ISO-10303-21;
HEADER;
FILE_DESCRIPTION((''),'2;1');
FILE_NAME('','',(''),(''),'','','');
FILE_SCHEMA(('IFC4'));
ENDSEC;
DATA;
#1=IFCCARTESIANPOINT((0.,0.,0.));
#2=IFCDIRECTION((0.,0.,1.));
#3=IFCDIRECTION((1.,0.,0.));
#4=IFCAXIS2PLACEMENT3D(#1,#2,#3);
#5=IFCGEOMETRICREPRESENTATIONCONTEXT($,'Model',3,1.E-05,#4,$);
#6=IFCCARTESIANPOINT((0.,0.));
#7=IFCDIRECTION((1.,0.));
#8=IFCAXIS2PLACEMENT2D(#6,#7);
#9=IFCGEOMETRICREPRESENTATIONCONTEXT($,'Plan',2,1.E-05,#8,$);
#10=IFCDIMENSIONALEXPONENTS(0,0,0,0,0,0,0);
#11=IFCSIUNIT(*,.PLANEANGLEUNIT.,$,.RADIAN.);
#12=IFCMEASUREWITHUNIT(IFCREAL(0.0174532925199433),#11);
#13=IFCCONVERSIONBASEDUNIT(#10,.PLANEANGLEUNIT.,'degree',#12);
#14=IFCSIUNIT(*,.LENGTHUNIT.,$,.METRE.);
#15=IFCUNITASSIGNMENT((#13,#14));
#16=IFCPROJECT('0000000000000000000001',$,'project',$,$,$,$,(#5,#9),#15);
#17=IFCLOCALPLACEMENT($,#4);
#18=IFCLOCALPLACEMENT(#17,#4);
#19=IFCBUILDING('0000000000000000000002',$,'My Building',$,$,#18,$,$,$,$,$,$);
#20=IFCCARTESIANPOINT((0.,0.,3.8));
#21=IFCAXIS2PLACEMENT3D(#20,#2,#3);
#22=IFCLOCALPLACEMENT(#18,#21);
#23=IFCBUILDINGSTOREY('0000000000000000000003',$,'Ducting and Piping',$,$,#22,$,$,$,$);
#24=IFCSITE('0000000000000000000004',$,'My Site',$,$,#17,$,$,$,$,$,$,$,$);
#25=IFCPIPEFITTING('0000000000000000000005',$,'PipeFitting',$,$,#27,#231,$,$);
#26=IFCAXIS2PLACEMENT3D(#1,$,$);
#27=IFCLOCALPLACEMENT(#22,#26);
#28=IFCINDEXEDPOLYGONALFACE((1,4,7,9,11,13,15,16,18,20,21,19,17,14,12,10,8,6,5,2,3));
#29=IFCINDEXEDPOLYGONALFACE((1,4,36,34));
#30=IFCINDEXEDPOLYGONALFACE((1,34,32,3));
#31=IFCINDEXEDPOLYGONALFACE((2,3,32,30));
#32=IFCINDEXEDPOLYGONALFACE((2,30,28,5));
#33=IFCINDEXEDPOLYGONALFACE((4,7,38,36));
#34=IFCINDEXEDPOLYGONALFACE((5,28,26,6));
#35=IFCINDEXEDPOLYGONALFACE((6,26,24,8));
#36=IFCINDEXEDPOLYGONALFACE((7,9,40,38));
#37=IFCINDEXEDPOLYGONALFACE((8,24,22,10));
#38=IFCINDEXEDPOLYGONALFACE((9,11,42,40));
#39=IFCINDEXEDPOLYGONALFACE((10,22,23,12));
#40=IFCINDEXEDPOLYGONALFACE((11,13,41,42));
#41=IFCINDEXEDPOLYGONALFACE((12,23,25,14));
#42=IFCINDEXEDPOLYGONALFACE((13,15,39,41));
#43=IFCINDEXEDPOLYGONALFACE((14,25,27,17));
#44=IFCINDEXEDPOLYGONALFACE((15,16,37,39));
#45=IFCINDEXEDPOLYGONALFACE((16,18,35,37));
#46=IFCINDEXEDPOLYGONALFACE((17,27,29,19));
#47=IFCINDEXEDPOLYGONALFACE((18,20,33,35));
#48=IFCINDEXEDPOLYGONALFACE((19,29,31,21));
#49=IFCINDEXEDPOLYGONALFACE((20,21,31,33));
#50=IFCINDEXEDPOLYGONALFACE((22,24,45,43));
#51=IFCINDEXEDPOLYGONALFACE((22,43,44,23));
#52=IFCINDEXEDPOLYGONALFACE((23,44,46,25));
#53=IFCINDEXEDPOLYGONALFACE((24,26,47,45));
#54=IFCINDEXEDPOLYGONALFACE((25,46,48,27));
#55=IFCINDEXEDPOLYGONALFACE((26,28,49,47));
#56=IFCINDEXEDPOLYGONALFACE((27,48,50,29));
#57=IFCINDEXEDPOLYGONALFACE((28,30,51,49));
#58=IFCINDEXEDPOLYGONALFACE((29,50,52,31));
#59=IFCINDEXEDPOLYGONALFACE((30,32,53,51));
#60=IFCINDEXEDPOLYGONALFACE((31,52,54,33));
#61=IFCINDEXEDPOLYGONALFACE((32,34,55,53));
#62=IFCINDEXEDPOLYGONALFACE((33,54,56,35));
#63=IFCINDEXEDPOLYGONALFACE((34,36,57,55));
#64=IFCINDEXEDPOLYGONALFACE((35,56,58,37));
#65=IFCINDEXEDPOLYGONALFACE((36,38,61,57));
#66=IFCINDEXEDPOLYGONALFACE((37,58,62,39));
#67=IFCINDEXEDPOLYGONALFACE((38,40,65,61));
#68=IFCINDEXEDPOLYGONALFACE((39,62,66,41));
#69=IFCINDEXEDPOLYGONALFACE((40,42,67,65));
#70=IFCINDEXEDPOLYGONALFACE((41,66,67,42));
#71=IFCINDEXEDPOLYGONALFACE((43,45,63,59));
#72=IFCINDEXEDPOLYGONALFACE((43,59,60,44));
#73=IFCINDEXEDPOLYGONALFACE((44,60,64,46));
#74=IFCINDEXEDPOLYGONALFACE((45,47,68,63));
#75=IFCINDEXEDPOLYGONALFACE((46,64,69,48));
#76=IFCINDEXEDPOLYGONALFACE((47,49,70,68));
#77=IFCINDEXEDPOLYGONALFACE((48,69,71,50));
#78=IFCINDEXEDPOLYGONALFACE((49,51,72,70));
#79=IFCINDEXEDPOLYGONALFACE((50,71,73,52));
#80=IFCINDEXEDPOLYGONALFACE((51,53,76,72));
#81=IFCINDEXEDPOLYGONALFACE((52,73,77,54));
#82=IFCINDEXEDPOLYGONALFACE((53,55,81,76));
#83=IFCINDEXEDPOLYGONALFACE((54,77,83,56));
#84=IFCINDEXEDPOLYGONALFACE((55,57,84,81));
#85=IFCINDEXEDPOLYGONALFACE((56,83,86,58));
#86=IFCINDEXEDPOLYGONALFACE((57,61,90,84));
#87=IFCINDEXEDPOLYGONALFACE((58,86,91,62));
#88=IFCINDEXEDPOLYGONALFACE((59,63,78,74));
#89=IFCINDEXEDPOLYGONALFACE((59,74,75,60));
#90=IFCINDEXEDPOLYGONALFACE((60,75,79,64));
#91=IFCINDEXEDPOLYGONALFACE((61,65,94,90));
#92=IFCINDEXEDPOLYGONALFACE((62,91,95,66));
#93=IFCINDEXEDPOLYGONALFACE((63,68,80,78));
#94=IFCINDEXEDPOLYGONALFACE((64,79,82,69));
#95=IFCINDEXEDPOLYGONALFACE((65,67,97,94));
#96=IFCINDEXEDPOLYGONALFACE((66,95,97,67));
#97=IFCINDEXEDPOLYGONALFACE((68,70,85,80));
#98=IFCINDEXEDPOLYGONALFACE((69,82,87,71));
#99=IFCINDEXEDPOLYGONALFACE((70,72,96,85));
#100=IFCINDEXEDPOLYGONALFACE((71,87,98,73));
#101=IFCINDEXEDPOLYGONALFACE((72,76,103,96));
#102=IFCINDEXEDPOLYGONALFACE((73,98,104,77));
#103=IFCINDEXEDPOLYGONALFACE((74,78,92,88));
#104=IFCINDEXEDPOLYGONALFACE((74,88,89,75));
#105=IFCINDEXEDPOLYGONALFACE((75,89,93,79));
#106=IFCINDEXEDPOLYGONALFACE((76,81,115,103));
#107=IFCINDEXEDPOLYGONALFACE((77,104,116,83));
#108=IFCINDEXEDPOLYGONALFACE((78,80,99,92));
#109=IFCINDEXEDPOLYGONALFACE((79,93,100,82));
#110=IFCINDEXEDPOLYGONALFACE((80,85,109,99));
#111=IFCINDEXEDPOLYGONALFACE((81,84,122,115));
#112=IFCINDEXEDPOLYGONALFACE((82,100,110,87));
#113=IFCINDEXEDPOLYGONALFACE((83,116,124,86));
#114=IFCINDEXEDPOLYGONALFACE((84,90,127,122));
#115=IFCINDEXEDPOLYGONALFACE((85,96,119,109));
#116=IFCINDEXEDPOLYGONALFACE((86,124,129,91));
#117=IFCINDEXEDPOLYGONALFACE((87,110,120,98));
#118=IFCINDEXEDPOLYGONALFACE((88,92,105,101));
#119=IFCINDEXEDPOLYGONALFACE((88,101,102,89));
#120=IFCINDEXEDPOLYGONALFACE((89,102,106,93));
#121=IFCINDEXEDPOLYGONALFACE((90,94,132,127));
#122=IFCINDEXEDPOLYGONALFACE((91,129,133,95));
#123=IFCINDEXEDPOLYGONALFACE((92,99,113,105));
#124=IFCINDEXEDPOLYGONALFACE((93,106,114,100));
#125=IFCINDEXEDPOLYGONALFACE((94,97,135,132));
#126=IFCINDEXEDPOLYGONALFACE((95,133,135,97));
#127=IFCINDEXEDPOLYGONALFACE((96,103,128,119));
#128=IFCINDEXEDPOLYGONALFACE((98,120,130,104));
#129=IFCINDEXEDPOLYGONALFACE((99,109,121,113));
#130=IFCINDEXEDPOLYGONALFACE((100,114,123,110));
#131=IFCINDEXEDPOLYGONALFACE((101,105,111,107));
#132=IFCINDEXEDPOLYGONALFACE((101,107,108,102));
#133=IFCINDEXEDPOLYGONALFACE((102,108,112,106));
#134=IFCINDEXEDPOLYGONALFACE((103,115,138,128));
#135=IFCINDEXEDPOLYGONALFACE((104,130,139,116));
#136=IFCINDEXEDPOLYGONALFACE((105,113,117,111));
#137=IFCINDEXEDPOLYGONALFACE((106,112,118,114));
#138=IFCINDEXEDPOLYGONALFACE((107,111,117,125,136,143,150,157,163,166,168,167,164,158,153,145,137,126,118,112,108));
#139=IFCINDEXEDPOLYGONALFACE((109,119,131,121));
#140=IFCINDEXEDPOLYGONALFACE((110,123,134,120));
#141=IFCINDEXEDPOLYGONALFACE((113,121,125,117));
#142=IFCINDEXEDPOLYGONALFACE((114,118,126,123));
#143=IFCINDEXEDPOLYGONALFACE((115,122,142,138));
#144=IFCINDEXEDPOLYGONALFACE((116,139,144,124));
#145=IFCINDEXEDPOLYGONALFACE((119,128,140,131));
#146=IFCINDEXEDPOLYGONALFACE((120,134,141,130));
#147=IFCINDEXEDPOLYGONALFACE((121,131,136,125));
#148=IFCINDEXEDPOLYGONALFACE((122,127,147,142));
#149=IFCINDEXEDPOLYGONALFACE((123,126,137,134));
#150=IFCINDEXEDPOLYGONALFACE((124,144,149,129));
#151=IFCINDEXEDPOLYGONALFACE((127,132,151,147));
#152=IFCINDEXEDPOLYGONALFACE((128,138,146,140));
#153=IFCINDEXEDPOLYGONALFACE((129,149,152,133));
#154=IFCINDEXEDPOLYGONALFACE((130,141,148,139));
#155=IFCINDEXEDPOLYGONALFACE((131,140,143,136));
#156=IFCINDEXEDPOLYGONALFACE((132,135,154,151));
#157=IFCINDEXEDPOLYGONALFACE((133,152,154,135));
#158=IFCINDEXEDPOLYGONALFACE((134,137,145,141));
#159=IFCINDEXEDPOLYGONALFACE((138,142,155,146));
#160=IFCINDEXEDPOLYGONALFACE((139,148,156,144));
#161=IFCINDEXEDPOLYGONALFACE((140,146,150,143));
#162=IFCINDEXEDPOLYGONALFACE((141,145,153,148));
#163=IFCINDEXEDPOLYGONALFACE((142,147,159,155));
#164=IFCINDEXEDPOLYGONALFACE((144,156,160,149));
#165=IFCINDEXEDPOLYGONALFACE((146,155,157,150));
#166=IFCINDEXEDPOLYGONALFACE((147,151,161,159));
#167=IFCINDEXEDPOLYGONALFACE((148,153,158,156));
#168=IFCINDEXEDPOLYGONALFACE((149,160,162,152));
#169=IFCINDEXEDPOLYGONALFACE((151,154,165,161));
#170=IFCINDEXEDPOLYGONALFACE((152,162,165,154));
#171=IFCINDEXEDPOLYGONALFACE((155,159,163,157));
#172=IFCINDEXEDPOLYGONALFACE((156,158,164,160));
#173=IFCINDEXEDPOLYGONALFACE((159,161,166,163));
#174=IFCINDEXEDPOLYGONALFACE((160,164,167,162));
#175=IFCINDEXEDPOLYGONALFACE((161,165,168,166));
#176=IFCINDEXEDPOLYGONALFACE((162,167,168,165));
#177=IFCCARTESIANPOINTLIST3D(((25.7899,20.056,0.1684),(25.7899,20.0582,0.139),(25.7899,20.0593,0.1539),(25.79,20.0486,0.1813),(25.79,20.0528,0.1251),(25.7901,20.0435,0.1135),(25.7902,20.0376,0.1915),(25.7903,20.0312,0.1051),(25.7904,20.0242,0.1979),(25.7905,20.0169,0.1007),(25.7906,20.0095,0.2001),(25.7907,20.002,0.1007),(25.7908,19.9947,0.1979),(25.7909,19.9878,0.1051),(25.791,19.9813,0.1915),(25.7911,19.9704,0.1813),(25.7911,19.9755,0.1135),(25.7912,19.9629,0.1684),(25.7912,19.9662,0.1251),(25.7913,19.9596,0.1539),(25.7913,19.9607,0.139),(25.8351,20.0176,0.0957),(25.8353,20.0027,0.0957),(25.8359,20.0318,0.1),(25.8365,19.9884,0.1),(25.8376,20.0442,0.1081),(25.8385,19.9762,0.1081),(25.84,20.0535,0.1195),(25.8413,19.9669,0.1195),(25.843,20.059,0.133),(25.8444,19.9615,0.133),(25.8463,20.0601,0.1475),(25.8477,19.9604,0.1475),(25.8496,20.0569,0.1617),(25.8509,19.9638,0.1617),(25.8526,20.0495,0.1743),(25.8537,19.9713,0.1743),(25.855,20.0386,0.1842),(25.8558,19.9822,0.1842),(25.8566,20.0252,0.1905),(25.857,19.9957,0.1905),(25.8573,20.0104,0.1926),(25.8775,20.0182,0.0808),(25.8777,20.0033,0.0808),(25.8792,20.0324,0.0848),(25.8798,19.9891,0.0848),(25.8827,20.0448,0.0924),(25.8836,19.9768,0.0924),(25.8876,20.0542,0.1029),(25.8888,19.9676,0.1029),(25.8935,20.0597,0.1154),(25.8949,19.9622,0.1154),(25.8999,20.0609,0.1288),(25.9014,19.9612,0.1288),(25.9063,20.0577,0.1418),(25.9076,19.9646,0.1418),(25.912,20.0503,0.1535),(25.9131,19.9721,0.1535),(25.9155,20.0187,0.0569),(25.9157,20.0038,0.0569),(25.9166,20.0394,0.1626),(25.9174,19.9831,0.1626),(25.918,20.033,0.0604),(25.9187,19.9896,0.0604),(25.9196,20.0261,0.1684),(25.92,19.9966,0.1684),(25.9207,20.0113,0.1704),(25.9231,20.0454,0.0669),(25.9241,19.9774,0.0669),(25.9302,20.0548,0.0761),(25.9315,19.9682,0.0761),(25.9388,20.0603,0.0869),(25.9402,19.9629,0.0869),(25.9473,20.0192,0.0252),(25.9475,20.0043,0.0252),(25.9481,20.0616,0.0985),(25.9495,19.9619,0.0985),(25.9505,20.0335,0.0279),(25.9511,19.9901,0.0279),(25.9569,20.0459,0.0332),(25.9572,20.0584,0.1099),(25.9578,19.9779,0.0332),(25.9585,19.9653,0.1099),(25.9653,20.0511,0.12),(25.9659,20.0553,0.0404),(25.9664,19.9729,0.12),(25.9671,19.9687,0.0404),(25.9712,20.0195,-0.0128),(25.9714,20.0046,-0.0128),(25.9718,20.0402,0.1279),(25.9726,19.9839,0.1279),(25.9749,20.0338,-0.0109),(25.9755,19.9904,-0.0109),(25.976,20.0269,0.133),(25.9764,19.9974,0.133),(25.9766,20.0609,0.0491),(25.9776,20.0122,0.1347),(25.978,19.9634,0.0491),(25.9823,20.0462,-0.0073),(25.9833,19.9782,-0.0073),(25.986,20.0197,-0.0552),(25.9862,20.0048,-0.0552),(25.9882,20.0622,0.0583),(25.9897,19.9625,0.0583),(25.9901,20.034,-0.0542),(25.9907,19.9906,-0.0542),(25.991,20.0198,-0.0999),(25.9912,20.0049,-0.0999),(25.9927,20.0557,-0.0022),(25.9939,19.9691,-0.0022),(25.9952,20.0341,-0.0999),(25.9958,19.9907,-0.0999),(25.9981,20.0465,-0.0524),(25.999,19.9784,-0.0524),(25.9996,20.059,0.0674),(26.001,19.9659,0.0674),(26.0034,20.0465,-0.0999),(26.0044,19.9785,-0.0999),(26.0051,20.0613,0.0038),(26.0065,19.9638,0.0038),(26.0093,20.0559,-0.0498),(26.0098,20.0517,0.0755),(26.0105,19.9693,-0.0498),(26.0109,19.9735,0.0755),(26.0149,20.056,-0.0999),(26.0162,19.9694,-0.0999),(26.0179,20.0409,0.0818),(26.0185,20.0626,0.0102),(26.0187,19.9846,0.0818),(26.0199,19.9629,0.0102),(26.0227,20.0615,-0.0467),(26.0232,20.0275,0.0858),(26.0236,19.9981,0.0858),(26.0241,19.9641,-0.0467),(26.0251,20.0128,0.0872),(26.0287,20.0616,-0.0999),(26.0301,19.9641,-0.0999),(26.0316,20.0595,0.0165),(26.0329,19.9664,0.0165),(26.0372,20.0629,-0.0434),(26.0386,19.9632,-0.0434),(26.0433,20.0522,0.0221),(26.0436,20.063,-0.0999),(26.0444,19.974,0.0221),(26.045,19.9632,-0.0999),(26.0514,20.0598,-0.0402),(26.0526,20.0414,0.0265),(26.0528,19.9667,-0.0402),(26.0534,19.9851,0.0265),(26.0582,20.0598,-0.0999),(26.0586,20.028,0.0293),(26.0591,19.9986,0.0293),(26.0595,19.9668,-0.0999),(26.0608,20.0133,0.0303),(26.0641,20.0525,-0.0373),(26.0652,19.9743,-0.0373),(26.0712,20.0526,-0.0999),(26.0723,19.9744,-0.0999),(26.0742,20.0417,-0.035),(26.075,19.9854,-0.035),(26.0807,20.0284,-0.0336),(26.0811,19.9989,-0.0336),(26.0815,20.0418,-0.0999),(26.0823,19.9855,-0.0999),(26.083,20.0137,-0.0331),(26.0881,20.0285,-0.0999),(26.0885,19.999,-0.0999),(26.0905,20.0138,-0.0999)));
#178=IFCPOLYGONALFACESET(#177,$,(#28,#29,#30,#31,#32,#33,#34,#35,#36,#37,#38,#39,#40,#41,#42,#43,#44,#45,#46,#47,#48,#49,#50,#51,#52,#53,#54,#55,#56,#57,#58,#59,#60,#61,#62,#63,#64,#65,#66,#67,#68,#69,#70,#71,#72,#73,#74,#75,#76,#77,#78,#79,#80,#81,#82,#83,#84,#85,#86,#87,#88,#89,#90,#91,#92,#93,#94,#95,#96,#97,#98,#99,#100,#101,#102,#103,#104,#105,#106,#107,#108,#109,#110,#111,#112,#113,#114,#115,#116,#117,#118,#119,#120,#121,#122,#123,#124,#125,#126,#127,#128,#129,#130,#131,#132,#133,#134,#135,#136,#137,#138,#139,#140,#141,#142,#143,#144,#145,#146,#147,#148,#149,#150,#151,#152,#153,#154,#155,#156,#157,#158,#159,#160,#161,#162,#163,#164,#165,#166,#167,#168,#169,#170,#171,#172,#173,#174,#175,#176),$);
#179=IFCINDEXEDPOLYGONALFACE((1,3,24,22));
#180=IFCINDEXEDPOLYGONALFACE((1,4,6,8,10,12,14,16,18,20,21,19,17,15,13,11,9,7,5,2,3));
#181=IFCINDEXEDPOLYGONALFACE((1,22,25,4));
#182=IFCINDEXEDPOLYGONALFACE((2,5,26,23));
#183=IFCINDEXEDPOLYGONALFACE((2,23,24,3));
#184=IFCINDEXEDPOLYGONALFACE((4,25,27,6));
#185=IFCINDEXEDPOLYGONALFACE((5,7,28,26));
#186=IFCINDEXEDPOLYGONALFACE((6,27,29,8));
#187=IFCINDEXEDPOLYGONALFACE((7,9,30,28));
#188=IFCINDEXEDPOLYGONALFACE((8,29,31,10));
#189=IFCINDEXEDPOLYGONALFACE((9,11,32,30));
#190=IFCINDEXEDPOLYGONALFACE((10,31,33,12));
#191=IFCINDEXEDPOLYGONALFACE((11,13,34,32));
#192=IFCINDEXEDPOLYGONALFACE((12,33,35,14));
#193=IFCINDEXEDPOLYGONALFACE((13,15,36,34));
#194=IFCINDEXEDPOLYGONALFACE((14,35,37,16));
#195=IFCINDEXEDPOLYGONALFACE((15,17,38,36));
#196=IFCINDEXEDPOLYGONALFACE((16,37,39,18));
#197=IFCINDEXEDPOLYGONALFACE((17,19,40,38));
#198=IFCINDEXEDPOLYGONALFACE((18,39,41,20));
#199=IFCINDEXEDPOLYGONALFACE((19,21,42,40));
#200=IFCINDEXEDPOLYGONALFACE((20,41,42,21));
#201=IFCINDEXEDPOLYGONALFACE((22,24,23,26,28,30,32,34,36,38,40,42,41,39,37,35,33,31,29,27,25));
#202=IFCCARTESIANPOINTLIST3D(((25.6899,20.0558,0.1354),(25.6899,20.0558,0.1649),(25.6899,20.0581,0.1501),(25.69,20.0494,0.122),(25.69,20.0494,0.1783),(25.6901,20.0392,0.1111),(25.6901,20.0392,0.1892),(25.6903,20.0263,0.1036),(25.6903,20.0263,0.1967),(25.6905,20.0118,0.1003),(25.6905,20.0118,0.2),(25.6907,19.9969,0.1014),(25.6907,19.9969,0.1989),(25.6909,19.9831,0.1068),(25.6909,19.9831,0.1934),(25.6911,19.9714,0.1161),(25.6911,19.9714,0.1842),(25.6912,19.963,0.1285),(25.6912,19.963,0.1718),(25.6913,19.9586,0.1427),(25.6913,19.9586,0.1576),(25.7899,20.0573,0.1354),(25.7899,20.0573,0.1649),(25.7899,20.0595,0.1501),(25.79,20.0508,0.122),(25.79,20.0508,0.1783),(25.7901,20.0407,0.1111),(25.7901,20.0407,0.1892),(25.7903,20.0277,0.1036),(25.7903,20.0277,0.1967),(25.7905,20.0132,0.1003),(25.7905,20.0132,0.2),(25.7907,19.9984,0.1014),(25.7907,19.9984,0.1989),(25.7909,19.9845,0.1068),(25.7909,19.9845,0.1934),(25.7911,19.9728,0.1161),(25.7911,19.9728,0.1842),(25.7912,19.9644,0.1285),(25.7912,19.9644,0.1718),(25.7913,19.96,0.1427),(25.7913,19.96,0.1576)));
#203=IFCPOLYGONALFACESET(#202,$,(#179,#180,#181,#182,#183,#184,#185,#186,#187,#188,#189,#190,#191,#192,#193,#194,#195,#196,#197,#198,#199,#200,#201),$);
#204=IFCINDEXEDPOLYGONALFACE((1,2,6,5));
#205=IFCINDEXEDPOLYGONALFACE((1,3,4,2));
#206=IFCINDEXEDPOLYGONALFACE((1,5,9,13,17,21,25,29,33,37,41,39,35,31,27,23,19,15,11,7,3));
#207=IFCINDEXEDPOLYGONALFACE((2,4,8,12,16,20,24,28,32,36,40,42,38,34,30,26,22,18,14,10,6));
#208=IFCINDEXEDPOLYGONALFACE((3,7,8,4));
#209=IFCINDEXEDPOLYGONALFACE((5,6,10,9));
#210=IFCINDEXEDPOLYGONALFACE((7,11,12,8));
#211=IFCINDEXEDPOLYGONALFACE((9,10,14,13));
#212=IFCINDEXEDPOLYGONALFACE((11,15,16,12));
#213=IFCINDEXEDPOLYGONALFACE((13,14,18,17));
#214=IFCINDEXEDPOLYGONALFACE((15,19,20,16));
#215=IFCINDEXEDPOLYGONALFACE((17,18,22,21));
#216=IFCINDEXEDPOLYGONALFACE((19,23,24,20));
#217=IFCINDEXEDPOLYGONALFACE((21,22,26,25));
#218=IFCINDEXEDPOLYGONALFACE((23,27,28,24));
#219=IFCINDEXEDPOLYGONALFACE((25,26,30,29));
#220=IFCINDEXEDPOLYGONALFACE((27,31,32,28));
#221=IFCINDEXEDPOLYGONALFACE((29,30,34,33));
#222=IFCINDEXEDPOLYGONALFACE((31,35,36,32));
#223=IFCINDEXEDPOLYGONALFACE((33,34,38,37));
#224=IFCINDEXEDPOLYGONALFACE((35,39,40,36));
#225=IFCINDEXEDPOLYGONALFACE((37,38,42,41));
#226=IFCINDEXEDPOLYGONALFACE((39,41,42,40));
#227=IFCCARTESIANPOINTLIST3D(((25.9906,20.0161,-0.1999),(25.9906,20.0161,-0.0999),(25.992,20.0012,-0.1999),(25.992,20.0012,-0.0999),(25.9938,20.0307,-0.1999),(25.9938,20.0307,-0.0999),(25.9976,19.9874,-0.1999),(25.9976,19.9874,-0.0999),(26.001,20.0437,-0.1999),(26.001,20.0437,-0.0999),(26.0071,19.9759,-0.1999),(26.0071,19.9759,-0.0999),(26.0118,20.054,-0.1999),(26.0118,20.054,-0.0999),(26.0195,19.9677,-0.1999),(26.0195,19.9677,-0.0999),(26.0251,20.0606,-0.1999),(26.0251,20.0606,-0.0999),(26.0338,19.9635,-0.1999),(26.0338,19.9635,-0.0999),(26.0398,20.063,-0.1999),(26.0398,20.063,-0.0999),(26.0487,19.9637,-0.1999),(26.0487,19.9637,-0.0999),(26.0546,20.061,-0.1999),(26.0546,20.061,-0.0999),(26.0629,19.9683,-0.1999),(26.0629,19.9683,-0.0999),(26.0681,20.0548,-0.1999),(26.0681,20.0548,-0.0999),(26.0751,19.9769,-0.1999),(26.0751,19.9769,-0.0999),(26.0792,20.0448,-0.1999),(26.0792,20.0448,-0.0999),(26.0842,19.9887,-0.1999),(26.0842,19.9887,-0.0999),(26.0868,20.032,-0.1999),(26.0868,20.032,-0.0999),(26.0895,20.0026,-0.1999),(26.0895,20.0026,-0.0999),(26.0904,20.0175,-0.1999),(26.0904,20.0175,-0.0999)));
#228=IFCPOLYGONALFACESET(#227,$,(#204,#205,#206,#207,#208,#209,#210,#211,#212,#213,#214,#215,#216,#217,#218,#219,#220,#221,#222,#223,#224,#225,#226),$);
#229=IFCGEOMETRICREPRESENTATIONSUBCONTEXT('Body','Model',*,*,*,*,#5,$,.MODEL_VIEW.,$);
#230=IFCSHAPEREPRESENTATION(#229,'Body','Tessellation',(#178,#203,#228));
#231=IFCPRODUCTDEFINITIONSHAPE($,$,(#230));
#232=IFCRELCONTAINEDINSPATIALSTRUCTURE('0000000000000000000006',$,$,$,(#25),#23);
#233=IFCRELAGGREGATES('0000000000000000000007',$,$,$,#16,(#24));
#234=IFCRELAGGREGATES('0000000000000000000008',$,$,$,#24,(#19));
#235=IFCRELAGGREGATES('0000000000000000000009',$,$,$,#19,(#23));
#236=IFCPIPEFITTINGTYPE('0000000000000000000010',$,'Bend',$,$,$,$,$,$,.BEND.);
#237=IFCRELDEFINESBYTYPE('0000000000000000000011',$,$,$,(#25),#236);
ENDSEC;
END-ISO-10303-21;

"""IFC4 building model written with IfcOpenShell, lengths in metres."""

from ifc_helpers import new_model, entity, si_unit, converted_unit, frame, origin_with_axes, origin_2d_with_axis, place, context, subcontext, project, spatial, circle, extrude, source, transform, mapped, type_object, type_shapes, element, save


model = new_model("IFC4")

# Units and contexts
model_context = context("Model", 3, precision=1e-05, world=origin_with_axes())
plan_context = context("Plan", 2, precision=1e-05, world=origin_2d_with_axis())
body_context = subcontext(model_context, "Body", "Model", "MODEL_VIEW")
ifc_project = project(units=[converted_unit("PLANEANGLEUNIT", "degree", entity("IfcReal", 0.0174532925199433), si_unit("PLANEANGLEUNIT", "RADIAN"), dimensions=[0, 0, 0, 0, 0, 0, 0]), si_unit("LENGTHUNIT", "METRE")], contexts=[model_context, plan_context])

# Site, building, storey
site_placement = place(None, origin_with_axes())
site = spatial("IfcSite", under=ifc_project, at=site_placement, Name="My Site")
building_placement = place(site_placement, origin_with_axes())
building = spatial("IfcBuilding", under=site, at=building_placement, Name="My Building")
storey_placement = place(building_placement, frame((0.0, 0.0, 3.8), z_axis=(0.0, 0.0, 1.0), x_axis=(1.0, 0.0, 0.0)))
storey = spatial("IfcBuildingStorey", under=building, at=storey_placement, Name="Ducting and Piping")

# Pipe fitting
pipe_fitting_type = type_object("IfcPipeFittingType", Name="Bend", PredefinedType="BEND")
shared_shape = source(origin_with_axes(), body_context, "Body", "SolidModel", [
    entity("IfcSweptDiskSolid", entity("IfcIndexedPolyCurve", entity("IfcCartesianPointList3D", [[0.0, 0.0, 0.1], [0.0, -0.0732, 0.2768], [0.0, -0.25, 0.35]]), [entity("IfcArcIndex", [1, 2, 3])]), 0.05),
    extrude(circle(Radius=0.05), origin_with_axes(), (0.0, 0.0, 1.0), 0.1),
    extrude(circle(Radius=0.05), frame((0.0, -0.25, 0.35), z_axis=(0.0, -1.0, 0.0), x_axis=(1.0, 0.0, 0.0)), (0.0, 0.0, 1.0), 0.1),
])
type_shapes(pipe_fitting_type, [shared_shape])
for number, where, z_axis, x_axis, name in (
    (1, (25.6906, 20.0081, 0.1501), (0.999898, 0.014266, 0.0), (-0.014266, 0.999898, 0.0), "PipeFitting"),
):
    element("IfcPipeFitting", number, at=place(storey_placement, frame(where, z_axis=z_axis, x_axis=x_axis)), inside=storey, type_object=pipe_fitting_type, Name=name, context=body_context, shape_type="MappedRepresentation", body=[
        mapped(shared_shape, transform((0.0, 0.0, 0.0), x_axis=(1.0, 0.0, 0.0), y_axis=(0.0, 1.0, 0.0), z_axis=(0.0, 0.0, 1.0), scale=1.0)),
    ])

save(model, "model.ifc")
